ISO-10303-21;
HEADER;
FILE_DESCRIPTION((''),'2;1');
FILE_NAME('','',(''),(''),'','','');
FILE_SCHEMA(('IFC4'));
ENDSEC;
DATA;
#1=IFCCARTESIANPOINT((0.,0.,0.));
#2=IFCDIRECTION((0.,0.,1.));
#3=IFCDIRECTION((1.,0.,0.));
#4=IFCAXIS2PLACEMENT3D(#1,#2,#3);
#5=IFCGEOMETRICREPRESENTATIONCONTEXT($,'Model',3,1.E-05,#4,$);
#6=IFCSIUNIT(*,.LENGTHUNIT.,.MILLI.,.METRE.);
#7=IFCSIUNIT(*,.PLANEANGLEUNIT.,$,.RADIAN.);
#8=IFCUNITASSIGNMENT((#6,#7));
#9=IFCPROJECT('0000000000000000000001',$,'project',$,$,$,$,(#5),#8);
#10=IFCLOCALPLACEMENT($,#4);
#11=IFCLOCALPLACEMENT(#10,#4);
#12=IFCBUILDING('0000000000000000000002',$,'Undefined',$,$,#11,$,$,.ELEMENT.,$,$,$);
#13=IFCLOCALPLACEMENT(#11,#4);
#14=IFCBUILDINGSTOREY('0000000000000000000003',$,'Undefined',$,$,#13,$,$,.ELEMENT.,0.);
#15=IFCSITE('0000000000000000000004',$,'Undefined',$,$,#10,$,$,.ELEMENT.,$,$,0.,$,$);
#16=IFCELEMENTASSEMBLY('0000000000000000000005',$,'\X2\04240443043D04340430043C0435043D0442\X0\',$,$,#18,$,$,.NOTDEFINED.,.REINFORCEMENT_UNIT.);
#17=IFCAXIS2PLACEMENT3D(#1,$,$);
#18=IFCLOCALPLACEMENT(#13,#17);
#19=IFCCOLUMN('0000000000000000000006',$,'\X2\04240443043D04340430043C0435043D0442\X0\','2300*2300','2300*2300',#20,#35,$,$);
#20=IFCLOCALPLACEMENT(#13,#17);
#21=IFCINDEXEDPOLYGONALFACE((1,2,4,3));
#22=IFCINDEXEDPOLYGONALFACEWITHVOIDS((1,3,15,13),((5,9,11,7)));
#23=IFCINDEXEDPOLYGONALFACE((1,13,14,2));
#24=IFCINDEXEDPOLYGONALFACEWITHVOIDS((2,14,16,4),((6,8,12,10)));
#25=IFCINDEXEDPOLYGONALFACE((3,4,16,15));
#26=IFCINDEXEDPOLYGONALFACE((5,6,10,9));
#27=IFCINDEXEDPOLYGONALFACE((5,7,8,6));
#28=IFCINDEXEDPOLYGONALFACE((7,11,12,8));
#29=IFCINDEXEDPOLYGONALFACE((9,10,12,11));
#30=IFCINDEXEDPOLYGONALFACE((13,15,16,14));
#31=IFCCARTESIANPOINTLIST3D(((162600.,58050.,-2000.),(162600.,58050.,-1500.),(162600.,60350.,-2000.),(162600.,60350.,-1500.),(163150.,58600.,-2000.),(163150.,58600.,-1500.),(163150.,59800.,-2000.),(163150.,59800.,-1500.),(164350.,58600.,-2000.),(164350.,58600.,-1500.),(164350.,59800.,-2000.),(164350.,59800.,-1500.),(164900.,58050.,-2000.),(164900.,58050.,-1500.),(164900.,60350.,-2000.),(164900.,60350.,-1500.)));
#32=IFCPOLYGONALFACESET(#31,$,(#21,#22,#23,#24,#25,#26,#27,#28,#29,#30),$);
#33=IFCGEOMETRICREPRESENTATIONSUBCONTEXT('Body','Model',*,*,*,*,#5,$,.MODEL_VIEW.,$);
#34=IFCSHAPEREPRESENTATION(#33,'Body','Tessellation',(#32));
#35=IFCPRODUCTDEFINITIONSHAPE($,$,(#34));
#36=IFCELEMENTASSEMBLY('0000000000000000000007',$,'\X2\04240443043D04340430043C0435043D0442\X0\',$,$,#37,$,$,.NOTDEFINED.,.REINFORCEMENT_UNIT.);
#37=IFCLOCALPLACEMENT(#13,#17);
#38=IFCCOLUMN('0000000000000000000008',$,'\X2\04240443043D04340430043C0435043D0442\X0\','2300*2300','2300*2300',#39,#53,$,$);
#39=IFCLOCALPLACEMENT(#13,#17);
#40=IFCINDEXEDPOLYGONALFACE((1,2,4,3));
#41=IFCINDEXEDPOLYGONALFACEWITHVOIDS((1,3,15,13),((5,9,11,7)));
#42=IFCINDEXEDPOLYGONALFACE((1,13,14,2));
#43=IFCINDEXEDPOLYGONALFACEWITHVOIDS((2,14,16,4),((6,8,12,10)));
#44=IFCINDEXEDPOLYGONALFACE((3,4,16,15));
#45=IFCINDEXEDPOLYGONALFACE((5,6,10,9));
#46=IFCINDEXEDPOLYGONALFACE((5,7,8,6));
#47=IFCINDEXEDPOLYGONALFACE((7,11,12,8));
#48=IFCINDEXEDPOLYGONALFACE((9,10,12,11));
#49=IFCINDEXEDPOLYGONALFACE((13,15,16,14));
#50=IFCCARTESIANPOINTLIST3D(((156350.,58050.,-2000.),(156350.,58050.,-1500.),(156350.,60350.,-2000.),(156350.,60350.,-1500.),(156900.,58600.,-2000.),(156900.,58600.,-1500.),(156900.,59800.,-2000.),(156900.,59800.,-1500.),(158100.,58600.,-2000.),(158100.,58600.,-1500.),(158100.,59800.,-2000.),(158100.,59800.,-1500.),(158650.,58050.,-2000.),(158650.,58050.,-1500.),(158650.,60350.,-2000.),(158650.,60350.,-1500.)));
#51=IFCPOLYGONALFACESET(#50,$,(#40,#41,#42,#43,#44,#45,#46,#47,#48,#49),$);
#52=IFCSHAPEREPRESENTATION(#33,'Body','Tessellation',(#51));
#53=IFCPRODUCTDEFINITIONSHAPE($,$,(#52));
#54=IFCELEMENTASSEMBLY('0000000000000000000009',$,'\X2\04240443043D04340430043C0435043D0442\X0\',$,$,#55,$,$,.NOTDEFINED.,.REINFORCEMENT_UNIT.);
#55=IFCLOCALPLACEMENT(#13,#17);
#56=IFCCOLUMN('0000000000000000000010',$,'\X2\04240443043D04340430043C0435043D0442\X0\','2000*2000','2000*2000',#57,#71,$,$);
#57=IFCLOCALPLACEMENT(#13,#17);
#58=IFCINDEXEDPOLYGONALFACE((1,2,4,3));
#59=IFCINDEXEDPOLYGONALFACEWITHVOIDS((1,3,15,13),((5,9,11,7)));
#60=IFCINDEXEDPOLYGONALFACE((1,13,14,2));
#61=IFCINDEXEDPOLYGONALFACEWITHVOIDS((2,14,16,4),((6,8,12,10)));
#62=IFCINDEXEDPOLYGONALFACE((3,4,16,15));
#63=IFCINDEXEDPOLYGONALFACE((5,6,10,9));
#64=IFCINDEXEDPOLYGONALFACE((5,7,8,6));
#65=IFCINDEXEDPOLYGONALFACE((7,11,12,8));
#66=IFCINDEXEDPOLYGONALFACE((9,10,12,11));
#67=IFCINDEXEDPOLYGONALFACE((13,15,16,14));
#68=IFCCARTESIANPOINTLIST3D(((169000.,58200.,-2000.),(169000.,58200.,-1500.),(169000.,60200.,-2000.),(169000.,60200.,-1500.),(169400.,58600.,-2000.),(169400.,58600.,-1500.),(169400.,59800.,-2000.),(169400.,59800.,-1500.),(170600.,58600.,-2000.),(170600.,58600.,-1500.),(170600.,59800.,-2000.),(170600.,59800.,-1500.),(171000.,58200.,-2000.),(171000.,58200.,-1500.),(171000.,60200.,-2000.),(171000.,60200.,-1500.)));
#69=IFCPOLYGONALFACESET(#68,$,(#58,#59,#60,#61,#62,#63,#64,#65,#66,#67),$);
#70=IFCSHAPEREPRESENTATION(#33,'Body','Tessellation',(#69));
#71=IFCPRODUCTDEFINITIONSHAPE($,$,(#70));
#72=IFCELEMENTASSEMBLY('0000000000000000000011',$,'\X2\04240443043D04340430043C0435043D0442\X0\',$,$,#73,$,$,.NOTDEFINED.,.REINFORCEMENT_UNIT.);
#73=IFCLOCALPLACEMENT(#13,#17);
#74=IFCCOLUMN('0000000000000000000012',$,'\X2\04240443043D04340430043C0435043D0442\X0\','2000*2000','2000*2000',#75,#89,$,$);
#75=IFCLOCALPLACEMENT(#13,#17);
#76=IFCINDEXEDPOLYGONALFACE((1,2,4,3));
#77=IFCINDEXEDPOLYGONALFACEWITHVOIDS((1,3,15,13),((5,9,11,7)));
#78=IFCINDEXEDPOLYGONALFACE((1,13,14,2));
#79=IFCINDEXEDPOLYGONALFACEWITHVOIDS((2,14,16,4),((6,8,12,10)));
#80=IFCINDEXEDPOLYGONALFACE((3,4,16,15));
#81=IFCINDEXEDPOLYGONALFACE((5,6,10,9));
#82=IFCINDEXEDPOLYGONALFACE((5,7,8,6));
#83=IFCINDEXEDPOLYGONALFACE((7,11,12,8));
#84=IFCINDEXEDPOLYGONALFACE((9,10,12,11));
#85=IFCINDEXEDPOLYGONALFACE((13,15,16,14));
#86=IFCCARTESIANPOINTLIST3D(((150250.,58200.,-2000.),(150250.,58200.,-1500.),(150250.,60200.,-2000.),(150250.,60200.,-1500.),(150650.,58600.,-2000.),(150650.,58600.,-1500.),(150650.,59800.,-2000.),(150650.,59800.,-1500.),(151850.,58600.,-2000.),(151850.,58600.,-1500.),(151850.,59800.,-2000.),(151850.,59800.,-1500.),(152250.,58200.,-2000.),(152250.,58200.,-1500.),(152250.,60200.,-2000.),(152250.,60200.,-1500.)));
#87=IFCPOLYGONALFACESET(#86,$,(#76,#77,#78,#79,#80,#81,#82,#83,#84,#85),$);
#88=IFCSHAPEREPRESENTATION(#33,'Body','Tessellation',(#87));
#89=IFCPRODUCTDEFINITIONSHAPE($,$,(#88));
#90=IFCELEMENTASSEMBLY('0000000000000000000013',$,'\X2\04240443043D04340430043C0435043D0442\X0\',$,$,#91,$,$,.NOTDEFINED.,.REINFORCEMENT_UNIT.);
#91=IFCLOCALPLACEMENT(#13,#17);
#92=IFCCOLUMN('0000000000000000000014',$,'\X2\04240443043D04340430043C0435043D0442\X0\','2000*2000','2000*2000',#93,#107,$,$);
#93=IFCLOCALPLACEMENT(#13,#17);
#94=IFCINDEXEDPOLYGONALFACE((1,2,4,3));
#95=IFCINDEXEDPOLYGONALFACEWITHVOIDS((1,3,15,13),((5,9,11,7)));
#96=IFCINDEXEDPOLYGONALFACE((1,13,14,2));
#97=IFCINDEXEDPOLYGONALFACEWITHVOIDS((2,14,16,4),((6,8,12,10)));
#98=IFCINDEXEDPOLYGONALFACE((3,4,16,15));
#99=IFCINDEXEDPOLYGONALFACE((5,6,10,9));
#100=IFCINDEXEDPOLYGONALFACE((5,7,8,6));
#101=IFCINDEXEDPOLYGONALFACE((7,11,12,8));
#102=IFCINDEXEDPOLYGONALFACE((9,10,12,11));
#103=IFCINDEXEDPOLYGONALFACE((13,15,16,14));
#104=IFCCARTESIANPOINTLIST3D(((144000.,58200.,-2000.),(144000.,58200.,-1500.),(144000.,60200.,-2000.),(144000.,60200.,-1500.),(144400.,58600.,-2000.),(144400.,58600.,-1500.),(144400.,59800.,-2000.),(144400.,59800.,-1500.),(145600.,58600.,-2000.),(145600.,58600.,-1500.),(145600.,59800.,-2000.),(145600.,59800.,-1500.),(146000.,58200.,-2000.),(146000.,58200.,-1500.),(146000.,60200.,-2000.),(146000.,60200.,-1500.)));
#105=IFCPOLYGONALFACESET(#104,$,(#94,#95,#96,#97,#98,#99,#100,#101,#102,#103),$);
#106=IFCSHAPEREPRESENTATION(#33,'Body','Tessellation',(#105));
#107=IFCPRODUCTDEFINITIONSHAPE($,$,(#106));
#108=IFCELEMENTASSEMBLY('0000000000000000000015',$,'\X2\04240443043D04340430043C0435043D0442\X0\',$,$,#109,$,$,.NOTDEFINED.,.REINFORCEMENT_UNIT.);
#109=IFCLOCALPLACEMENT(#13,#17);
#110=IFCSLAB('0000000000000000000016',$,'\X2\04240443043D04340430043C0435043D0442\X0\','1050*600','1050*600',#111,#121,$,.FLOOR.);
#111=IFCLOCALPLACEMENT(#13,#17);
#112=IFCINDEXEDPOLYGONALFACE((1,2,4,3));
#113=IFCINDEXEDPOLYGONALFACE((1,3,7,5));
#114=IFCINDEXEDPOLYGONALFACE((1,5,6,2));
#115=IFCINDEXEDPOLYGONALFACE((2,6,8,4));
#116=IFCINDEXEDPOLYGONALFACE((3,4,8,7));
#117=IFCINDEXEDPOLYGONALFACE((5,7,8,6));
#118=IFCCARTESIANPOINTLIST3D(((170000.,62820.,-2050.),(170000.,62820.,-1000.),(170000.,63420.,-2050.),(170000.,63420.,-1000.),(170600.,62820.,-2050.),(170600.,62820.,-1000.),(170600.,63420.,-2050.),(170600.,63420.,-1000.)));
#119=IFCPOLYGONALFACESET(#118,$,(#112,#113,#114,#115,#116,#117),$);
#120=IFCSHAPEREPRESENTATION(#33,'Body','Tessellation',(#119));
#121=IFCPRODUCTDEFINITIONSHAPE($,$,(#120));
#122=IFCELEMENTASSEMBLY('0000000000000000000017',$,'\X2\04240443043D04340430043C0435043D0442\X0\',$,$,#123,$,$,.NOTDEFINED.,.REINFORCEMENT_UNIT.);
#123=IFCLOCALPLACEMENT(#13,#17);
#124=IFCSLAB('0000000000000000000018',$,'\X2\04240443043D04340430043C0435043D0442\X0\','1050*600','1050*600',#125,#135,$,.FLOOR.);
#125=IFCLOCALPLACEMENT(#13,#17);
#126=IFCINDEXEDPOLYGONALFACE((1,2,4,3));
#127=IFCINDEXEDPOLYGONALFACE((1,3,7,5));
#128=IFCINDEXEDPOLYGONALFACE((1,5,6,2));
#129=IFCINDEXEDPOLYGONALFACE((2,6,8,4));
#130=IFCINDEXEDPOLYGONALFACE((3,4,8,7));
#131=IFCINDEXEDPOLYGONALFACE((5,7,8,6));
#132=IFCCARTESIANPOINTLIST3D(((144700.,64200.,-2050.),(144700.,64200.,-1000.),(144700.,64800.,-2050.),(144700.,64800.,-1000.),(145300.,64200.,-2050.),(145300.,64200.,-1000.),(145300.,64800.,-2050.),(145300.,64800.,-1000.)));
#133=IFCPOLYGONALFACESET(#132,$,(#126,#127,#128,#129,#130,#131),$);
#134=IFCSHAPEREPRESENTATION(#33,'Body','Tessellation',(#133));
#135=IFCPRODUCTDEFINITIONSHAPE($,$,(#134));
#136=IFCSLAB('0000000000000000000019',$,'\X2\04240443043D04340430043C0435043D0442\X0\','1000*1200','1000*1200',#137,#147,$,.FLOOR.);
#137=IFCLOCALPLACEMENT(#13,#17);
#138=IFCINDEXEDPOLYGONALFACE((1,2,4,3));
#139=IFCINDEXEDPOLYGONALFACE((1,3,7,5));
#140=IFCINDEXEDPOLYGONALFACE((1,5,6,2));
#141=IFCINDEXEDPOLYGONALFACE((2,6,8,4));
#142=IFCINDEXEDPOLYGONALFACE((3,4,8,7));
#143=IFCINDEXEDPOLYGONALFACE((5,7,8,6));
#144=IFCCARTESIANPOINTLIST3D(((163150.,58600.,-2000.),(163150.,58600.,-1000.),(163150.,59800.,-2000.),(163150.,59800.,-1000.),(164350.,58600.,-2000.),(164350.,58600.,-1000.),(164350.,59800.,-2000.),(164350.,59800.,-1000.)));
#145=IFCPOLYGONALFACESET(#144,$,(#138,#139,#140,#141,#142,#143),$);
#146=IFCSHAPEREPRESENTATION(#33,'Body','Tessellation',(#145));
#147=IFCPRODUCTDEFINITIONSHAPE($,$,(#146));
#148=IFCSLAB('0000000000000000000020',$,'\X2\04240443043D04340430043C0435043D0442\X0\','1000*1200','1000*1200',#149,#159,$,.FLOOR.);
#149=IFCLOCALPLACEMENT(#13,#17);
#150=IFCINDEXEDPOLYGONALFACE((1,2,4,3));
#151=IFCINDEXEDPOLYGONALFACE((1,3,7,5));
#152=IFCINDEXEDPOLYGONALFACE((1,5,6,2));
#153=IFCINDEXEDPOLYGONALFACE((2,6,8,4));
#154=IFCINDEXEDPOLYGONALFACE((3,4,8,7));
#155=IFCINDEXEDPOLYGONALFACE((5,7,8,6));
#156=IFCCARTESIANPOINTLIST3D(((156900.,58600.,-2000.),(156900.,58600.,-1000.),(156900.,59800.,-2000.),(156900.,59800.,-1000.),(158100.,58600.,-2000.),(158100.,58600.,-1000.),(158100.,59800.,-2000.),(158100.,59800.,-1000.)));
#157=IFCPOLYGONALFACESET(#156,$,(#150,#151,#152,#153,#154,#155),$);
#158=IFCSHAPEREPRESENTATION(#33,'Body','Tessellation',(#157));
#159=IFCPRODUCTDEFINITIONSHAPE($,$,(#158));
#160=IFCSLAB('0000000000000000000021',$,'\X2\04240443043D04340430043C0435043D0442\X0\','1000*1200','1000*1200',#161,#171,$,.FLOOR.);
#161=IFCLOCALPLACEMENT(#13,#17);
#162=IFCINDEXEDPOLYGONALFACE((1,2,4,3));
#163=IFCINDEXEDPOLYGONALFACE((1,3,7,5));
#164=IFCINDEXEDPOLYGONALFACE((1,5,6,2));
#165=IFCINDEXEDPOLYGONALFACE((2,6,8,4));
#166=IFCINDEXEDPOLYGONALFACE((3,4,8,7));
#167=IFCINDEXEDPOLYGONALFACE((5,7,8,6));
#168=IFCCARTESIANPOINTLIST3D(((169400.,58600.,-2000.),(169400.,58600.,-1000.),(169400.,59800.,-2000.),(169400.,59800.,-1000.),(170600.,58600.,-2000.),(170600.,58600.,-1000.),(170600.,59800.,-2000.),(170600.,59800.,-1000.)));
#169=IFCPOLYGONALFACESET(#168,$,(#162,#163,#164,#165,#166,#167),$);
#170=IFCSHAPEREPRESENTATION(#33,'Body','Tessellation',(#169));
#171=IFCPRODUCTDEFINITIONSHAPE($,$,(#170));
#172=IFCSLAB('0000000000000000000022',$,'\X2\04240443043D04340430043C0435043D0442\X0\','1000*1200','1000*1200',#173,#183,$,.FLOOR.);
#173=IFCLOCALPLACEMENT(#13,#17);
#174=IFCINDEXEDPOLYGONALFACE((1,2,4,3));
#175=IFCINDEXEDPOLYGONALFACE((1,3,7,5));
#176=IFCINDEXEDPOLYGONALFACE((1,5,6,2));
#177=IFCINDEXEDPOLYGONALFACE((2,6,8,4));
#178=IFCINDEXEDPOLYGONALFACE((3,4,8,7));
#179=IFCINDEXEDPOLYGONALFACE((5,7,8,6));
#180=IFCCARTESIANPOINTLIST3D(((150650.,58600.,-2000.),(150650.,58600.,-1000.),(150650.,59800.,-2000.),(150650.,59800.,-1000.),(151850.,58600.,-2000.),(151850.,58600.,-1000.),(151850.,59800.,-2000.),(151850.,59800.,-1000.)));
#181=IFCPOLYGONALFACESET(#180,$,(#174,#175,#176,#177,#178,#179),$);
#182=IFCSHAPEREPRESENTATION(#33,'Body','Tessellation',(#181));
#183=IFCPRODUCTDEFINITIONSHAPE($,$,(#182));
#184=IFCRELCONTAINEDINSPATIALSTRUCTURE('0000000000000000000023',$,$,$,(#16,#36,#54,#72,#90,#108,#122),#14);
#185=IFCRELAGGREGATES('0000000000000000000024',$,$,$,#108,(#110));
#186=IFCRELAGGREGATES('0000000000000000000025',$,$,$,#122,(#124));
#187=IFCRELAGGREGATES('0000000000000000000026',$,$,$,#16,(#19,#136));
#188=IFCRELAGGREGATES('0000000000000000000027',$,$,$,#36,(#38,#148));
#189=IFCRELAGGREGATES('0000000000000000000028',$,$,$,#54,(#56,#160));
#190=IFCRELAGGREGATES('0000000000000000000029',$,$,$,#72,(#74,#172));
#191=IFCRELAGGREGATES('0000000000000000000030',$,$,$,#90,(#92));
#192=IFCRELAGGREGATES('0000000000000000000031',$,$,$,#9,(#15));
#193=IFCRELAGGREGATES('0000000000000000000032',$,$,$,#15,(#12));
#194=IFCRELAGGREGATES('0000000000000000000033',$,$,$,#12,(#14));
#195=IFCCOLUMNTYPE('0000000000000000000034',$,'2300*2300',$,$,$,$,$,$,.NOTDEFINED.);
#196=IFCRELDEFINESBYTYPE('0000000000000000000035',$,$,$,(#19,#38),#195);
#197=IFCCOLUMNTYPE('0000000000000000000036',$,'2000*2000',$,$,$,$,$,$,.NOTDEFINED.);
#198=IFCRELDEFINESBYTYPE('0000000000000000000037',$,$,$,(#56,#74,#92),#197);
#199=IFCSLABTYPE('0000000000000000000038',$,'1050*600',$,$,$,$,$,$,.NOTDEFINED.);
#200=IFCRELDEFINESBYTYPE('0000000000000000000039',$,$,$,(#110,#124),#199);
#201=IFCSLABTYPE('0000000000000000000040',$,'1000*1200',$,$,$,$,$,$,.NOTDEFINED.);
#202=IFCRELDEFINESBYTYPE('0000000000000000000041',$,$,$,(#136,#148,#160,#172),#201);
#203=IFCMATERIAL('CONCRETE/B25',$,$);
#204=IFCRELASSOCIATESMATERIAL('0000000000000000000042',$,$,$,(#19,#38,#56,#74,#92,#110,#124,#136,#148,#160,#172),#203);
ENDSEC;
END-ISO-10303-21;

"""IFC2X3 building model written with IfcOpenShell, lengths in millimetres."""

from ifc_helpers import new_model, si_unit, frame, origin_with_axes, origin_2d_with_axis, place, context, subcontext, project, spatial, polyline, rectangle, outline, extrude, boolean, material, type_object, element, aggregate, save


model = new_model("IFC2X3")

# Units and contexts
model_context = context("Model", 3, precision=1e-05, world=origin_with_axes())
body_context = subcontext(model_context, "Body", "Model", "MODEL_VIEW")
ifc_project = project(units=[si_unit("LENGTHUNIT", "METRE", prefix="MILLI"), si_unit("PLANEANGLEUNIT", "RADIAN")], contexts=[model_context])

# Site, building, storey
site_placement = place(None, origin_with_axes())
site = spatial("IfcSite", under=ifc_project, at=site_placement, Name="Undefined", CompositionType="ELEMENT", RefElevation=0.0)
building_placement = place(site_placement, origin_with_axes())
building = spatial("IfcBuilding", under=site, at=building_placement, Name="Undefined", CompositionType="ELEMENT")
storey_placement = place(building_placement, origin_with_axes())
storey = spatial("IfcBuildingStorey", under=building, at=storey_placement, Name="Undefined", CompositionType="ELEMENT", Elevation=0.0)

# Element assemblies, columns
assembly_1_placement = place(storey_placement, origin_with_axes())
assembly_1 = element("IfcElementAssembly", 1, at=assembly_1_placement, inside=storey, Name="Фундамент", AssemblyPlace="NOTDEFINED", PredefinedType="REINFORCEMENT_UNIT")
ifc_material_1 = material(Name="CONCRETE/B25")
column_type_1 = type_object("IfcColumnType", Name="2300*2300", PredefinedType="NOTDEFINED")
column_1_placement = place(assembly_1_placement, frame((163750.0, 59200.0, -2000.0), z_axis=(0.0, 0.0, 1.0), x_axis=(0.0, -1.0, 0.0)))
column_1 = element("IfcColumn", 2, at=column_1_placement, type_object=column_type_1, material=ifc_material_1, Name="Фундамент", Description="2300*2300", ObjectType="2300*2300", context=body_context, shape_type="CSG", body=[
    boolean("DIFFERENCE", extrude(rectangle(XDim=2300.0, YDim=2300.0, at=origin_2d_with_axis()), frame((0.0, 0.0, 500.0), z_axis=(0.0, 0.0, -1.0), x_axis=(0.0, 1.0, 0.0)), (0.0, 0.0, 1.0), 500.0), extrude(outline(polyline([(0.0, 0.0), (1200.0, 0.0), (1200.0, 1200.0), (0.0, 1200.0), (0.0, 0.0)])), frame((-600.0, -600.0, -100.0), z_axis=(0.0, 0.0, 1.0), x_axis=(1.0, 0.0, 0.0)), (0.0, 0.0, 1.0), 700.0)),
])
assembly_2_placement = place(storey_placement, origin_with_axes())
assembly_2 = element("IfcElementAssembly", 3, at=assembly_2_placement, inside=storey, Name="Фундамент", AssemblyPlace="NOTDEFINED", PredefinedType="REINFORCEMENT_UNIT")
column_2_placement = place(assembly_2_placement, frame((157500.0, 59200.0, -2000.0), z_axis=(0.0, 0.0, 1.0), x_axis=(0.0, -1.0, 0.0)))
column_2 = element("IfcColumn", 4, at=column_2_placement, type_object=column_type_1, material=ifc_material_1, Name="Фундамент", Description="2300*2300", ObjectType="2300*2300", context=body_context, shape_type="CSG", body=[
    boolean("DIFFERENCE", extrude(rectangle(XDim=2300.0, YDim=2300.0, at=origin_2d_with_axis()), frame((0.0, 0.0, 500.0), z_axis=(0.0, 0.0, -1.0), x_axis=(0.0, 1.0, 0.0)), (0.0, 0.0, 1.0), 500.0), extrude(outline(polyline([(0.0, 0.0), (1200.0, 0.0), (1200.0, 1200.0), (0.0, 1200.0), (0.0, 0.0)])), frame((-600.0, -600.0, -100.0), z_axis=(0.0, 0.0, 1.0), x_axis=(1.0, 0.0, 0.0)), (0.0, 0.0, 1.0), 700.0)),
])
assembly_3_placement = place(storey_placement, origin_with_axes())
assembly_3 = element("IfcElementAssembly", 5, at=assembly_3_placement, inside=storey, Name="Фундамент", AssemblyPlace="NOTDEFINED", PredefinedType="REINFORCEMENT_UNIT")
column_type_2 = type_object("IfcColumnType", Name="2000*2000", PredefinedType="NOTDEFINED")
column_3_placement = place(assembly_3_placement, frame((170000.0, 59200.0, -2000.0), z_axis=(0.0, 0.0, 1.0), x_axis=(0.0, -1.0, 0.0)))
column_3 = element("IfcColumn", 6, at=column_3_placement, type_object=column_type_2, material=ifc_material_1, Name="Фундамент", Description="2000*2000", ObjectType="2000*2000", context=body_context, shape_type="CSG", body=[
    boolean("DIFFERENCE", extrude(rectangle(XDim=2000.0, YDim=2000.0, at=origin_2d_with_axis()), frame((0.0, 0.0, 500.0), z_axis=(0.0, 0.0, -1.0), x_axis=(0.0, 1.0, 0.0)), (0.0, 0.0, 1.0), 500.0), extrude(outline(polyline([(0.0, 0.0), (1200.0, 0.0), (1200.0, 1200.0), (0.0, 1200.0), (0.0, 0.0)])), frame((-600.0, -600.0, -100.0), z_axis=(0.0, 0.0, 1.0), x_axis=(1.0, 0.0, 0.0)), (0.0, 0.0, 1.0), 700.0)),
])
assembly_4_placement = place(storey_placement, origin_with_axes())
assembly_4 = element("IfcElementAssembly", 7, at=assembly_4_placement, inside=storey, Name="Фундамент", AssemblyPlace="NOTDEFINED", PredefinedType="REINFORCEMENT_UNIT")
column_4_placement = place(assembly_4_placement, frame((151250.0, 59200.0, -2000.0), z_axis=(0.0, 0.0, 1.0), x_axis=(0.0, -1.0, 0.0)))
column_4 = element("IfcColumn", 8, at=column_4_placement, type_object=column_type_2, material=ifc_material_1, Name="Фундамент", Description="2000*2000", ObjectType="2000*2000", context=body_context, shape_type="CSG", body=[
    boolean("DIFFERENCE", extrude(rectangle(XDim=2000.0, YDim=2000.0, at=origin_2d_with_axis()), frame((0.0, 0.0, 500.0), z_axis=(0.0, 0.0, -1.0), x_axis=(0.0, 1.0, 0.0)), (0.0, 0.0, 1.0), 500.0), extrude(outline(polyline([(0.0, 0.0), (1200.0, 0.0), (1200.0, 1200.0), (0.0, 1200.0), (0.0, 0.0)])), frame((-600.0, -600.0, -100.0), z_axis=(0.0, 0.0, 1.0), x_axis=(1.0, 0.0, 0.0)), (0.0, 0.0, 1.0), 700.0)),
])
assembly_5_placement = place(storey_placement, origin_with_axes())
assembly_5 = element("IfcElementAssembly", 9, at=assembly_5_placement, inside=storey, Name="Фундамент", AssemblyPlace="NOTDEFINED", PredefinedType="REINFORCEMENT_UNIT")
column_5_placement = place(assembly_5_placement, frame((145000.0, 59200.0, -2000.0), z_axis=(0.0, 0.0, 1.0), x_axis=(0.0, -1.0, 0.0)))
column_5 = element("IfcColumn", 10, at=column_5_placement, type_object=column_type_2, material=ifc_material_1, Name="Фундамент", Description="2000*2000", ObjectType="2000*2000", context=body_context, shape_type="CSG", body=[
    boolean("DIFFERENCE", extrude(rectangle(XDim=2000.0, YDim=2000.0, at=origin_2d_with_axis()), frame((0.0, 0.0, 500.0), z_axis=(0.0, 0.0, -1.0), x_axis=(0.0, 1.0, 0.0)), (0.0, 0.0, 1.0), 500.0), extrude(outline(polyline([(0.0, 0.0), (1200.0, 0.0), (1200.0, 1200.0), (0.0, 1200.0), (0.0, 0.0)])), frame((-600.0, -600.0, -100.0), z_axis=(0.0, 0.0, 1.0), x_axis=(1.0, 0.0, 0.0)), (0.0, 0.0, 1.0), 700.0)),
])

# Element assemblies, slabs
assembly_6_placement = place(storey_placement, origin_with_axes())
assembly_6 = element("IfcElementAssembly", 11, at=assembly_6_placement, inside=storey, Name="Фундамент", AssemblyPlace="NOTDEFINED", PredefinedType="REINFORCEMENT_UNIT")
slab_type_1 = type_object("IfcSlabType", Name="1050*600", PredefinedType="NOTDEFINED")
slab_1_placement = place(assembly_6_placement, frame((170000.0, 63420.0, -1525.0), z_axis=(0.0, 0.0, 1.0), x_axis=(0.0, -1.0, 0.0)))
slab_1 = element("IfcSlab", 12, at=slab_1_placement, type_object=slab_type_1, material=ifc_material_1, Name="Фундамент", Description="1050*600", ObjectType="1050*600", PredefinedType="FLOOR", context=body_context, shape_type="SweptSolid", body=[
    extrude(outline(polyline([(0.0, 0.0), (600.0, 0.0), (600.0, 600.0), (0.0, 600.0), (0.0, 0.0)])), frame((0.0, 0.0, -525.0), z_axis=(0.0, 0.0, 1.0), x_axis=(1.0, 0.0, 0.0)), (0.0, 0.0, 1.0), 1050.0),
])
aggregate(assembly_6, [slab_1])
assembly_7_placement = place(storey_placement, origin_with_axes())
assembly_7 = element("IfcElementAssembly", 13, at=assembly_7_placement, inside=storey, Name="Фундамент", AssemblyPlace="NOTDEFINED", PredefinedType="REINFORCEMENT_UNIT")
slab_2_placement = place(assembly_7_placement, frame((144700.0, 64800.0, -1525.0), z_axis=(0.0, 0.0, 1.0), x_axis=(0.0, -1.0, 0.0)))
slab_2 = element("IfcSlab", 14, at=slab_2_placement, type_object=slab_type_1, material=ifc_material_1, Name="Фундамент", Description="1050*600", ObjectType="1050*600", PredefinedType="FLOOR", context=body_context, shape_type="SweptSolid", body=[
    extrude(outline(polyline([(0.0, 0.0), (600.0, 0.0), (600.0, 600.0), (0.0, 600.0), (0.0, 0.0)])), frame((0.0, 0.0, -525.0), z_axis=(0.0, 0.0, 1.0), x_axis=(1.0, 0.0, 0.0)), (0.0, 0.0, 1.0), 1050.0),
])
aggregate(assembly_7, [slab_2])

# Slabs
slab_type_2 = type_object("IfcSlabType", Name="1000*1200", PredefinedType="NOTDEFINED")
slab_3_placement = place(assembly_1_placement, frame((163150.0, 59800.0, -1500.0), z_axis=(0.0, 0.0, 1.0), x_axis=(0.0, -1.0, 0.0)))
slab_3 = element("IfcSlab", 15, at=slab_3_placement, type_object=slab_type_2, material=ifc_material_1, Name="Фундамент", Description="1000*1200", ObjectType="1000*1200", PredefinedType="FLOOR", context=body_context, shape_type="SweptSolid", body=[
    extrude(outline(polyline([(0.0, 0.0), (1200.0, 0.0), (1200.0, 1200.0), (0.0, 1200.0), (0.0, 0.0)])), frame((0.0, 0.0, -500.0), z_axis=(0.0, 0.0, 1.0), x_axis=(1.0, 0.0, 0.0)), (0.0, 0.0, 1.0), 1000.0),
])
slab_4_placement = place(assembly_2_placement, frame((156900.0, 59800.0, -1500.0), z_axis=(0.0, 0.0, 1.0), x_axis=(0.0, -1.0, 0.0)))
slab_4 = element("IfcSlab", 16, at=slab_4_placement, type_object=slab_type_2, material=ifc_material_1, Name="Фундамент", Description="1000*1200", ObjectType="1000*1200", PredefinedType="FLOOR", context=body_context, shape_type="SweptSolid", body=[
    extrude(outline(polyline([(0.0, 0.0), (1200.0, 0.0), (1200.0, 1200.0), (0.0, 1200.0), (0.0, 0.0)])), frame((0.0, 0.0, -500.0), z_axis=(0.0, 0.0, 1.0), x_axis=(1.0, 0.0, 0.0)), (0.0, 0.0, 1.0), 1000.0),
])
slab_5_placement = place(assembly_3_placement, frame((169400.0, 59800.0, -1500.0), z_axis=(0.0, 0.0, 1.0), x_axis=(0.0, -1.0, 0.0)))
slab_5 = element("IfcSlab", 17, at=slab_5_placement, type_object=slab_type_2, material=ifc_material_1, Name="Фундамент", Description="1000*1200", ObjectType="1000*1200", PredefinedType="FLOOR", context=body_context, shape_type="SweptSolid", body=[
    extrude(outline(polyline([(0.0, 0.0), (1200.0, 0.0), (1200.0, 1200.0), (0.0, 1200.0), (0.0, 0.0)])), frame((0.0, 0.0, -500.0), z_axis=(0.0, 0.0, 1.0), x_axis=(1.0, 0.0, 0.0)), (0.0, 0.0, 1.0), 1000.0),
])
slab_6_placement = place(assembly_4_placement, frame((150650.0, 59800.0, -1500.0), z_axis=(0.0, 0.0, 1.0), x_axis=(0.0, -1.0, 0.0)))
slab_6 = element("IfcSlab", 18, at=slab_6_placement, type_object=slab_type_2, material=ifc_material_1, Name="Фундамент", Description="1000*1200", ObjectType="1000*1200", PredefinedType="FLOOR", context=body_context, shape_type="SweptSolid", body=[
    extrude(outline(polyline([(0.0, 0.0), (1200.0, 0.0), (1200.0, 1200.0), (0.0, 1200.0), (0.0, 0.0)])), frame((0.0, 0.0, -500.0), z_axis=(0.0, 0.0, 1.0), x_axis=(1.0, 0.0, 0.0)), (0.0, 0.0, 1.0), 1000.0),
])
aggregate(assembly_1, [column_1, slab_3])
aggregate(assembly_2, [column_2, slab_4])
aggregate(assembly_3, [column_3, slab_5])
aggregate(assembly_4, [column_4, slab_6])
aggregate(assembly_5, [column_5])

save(model, "model.ifc")
